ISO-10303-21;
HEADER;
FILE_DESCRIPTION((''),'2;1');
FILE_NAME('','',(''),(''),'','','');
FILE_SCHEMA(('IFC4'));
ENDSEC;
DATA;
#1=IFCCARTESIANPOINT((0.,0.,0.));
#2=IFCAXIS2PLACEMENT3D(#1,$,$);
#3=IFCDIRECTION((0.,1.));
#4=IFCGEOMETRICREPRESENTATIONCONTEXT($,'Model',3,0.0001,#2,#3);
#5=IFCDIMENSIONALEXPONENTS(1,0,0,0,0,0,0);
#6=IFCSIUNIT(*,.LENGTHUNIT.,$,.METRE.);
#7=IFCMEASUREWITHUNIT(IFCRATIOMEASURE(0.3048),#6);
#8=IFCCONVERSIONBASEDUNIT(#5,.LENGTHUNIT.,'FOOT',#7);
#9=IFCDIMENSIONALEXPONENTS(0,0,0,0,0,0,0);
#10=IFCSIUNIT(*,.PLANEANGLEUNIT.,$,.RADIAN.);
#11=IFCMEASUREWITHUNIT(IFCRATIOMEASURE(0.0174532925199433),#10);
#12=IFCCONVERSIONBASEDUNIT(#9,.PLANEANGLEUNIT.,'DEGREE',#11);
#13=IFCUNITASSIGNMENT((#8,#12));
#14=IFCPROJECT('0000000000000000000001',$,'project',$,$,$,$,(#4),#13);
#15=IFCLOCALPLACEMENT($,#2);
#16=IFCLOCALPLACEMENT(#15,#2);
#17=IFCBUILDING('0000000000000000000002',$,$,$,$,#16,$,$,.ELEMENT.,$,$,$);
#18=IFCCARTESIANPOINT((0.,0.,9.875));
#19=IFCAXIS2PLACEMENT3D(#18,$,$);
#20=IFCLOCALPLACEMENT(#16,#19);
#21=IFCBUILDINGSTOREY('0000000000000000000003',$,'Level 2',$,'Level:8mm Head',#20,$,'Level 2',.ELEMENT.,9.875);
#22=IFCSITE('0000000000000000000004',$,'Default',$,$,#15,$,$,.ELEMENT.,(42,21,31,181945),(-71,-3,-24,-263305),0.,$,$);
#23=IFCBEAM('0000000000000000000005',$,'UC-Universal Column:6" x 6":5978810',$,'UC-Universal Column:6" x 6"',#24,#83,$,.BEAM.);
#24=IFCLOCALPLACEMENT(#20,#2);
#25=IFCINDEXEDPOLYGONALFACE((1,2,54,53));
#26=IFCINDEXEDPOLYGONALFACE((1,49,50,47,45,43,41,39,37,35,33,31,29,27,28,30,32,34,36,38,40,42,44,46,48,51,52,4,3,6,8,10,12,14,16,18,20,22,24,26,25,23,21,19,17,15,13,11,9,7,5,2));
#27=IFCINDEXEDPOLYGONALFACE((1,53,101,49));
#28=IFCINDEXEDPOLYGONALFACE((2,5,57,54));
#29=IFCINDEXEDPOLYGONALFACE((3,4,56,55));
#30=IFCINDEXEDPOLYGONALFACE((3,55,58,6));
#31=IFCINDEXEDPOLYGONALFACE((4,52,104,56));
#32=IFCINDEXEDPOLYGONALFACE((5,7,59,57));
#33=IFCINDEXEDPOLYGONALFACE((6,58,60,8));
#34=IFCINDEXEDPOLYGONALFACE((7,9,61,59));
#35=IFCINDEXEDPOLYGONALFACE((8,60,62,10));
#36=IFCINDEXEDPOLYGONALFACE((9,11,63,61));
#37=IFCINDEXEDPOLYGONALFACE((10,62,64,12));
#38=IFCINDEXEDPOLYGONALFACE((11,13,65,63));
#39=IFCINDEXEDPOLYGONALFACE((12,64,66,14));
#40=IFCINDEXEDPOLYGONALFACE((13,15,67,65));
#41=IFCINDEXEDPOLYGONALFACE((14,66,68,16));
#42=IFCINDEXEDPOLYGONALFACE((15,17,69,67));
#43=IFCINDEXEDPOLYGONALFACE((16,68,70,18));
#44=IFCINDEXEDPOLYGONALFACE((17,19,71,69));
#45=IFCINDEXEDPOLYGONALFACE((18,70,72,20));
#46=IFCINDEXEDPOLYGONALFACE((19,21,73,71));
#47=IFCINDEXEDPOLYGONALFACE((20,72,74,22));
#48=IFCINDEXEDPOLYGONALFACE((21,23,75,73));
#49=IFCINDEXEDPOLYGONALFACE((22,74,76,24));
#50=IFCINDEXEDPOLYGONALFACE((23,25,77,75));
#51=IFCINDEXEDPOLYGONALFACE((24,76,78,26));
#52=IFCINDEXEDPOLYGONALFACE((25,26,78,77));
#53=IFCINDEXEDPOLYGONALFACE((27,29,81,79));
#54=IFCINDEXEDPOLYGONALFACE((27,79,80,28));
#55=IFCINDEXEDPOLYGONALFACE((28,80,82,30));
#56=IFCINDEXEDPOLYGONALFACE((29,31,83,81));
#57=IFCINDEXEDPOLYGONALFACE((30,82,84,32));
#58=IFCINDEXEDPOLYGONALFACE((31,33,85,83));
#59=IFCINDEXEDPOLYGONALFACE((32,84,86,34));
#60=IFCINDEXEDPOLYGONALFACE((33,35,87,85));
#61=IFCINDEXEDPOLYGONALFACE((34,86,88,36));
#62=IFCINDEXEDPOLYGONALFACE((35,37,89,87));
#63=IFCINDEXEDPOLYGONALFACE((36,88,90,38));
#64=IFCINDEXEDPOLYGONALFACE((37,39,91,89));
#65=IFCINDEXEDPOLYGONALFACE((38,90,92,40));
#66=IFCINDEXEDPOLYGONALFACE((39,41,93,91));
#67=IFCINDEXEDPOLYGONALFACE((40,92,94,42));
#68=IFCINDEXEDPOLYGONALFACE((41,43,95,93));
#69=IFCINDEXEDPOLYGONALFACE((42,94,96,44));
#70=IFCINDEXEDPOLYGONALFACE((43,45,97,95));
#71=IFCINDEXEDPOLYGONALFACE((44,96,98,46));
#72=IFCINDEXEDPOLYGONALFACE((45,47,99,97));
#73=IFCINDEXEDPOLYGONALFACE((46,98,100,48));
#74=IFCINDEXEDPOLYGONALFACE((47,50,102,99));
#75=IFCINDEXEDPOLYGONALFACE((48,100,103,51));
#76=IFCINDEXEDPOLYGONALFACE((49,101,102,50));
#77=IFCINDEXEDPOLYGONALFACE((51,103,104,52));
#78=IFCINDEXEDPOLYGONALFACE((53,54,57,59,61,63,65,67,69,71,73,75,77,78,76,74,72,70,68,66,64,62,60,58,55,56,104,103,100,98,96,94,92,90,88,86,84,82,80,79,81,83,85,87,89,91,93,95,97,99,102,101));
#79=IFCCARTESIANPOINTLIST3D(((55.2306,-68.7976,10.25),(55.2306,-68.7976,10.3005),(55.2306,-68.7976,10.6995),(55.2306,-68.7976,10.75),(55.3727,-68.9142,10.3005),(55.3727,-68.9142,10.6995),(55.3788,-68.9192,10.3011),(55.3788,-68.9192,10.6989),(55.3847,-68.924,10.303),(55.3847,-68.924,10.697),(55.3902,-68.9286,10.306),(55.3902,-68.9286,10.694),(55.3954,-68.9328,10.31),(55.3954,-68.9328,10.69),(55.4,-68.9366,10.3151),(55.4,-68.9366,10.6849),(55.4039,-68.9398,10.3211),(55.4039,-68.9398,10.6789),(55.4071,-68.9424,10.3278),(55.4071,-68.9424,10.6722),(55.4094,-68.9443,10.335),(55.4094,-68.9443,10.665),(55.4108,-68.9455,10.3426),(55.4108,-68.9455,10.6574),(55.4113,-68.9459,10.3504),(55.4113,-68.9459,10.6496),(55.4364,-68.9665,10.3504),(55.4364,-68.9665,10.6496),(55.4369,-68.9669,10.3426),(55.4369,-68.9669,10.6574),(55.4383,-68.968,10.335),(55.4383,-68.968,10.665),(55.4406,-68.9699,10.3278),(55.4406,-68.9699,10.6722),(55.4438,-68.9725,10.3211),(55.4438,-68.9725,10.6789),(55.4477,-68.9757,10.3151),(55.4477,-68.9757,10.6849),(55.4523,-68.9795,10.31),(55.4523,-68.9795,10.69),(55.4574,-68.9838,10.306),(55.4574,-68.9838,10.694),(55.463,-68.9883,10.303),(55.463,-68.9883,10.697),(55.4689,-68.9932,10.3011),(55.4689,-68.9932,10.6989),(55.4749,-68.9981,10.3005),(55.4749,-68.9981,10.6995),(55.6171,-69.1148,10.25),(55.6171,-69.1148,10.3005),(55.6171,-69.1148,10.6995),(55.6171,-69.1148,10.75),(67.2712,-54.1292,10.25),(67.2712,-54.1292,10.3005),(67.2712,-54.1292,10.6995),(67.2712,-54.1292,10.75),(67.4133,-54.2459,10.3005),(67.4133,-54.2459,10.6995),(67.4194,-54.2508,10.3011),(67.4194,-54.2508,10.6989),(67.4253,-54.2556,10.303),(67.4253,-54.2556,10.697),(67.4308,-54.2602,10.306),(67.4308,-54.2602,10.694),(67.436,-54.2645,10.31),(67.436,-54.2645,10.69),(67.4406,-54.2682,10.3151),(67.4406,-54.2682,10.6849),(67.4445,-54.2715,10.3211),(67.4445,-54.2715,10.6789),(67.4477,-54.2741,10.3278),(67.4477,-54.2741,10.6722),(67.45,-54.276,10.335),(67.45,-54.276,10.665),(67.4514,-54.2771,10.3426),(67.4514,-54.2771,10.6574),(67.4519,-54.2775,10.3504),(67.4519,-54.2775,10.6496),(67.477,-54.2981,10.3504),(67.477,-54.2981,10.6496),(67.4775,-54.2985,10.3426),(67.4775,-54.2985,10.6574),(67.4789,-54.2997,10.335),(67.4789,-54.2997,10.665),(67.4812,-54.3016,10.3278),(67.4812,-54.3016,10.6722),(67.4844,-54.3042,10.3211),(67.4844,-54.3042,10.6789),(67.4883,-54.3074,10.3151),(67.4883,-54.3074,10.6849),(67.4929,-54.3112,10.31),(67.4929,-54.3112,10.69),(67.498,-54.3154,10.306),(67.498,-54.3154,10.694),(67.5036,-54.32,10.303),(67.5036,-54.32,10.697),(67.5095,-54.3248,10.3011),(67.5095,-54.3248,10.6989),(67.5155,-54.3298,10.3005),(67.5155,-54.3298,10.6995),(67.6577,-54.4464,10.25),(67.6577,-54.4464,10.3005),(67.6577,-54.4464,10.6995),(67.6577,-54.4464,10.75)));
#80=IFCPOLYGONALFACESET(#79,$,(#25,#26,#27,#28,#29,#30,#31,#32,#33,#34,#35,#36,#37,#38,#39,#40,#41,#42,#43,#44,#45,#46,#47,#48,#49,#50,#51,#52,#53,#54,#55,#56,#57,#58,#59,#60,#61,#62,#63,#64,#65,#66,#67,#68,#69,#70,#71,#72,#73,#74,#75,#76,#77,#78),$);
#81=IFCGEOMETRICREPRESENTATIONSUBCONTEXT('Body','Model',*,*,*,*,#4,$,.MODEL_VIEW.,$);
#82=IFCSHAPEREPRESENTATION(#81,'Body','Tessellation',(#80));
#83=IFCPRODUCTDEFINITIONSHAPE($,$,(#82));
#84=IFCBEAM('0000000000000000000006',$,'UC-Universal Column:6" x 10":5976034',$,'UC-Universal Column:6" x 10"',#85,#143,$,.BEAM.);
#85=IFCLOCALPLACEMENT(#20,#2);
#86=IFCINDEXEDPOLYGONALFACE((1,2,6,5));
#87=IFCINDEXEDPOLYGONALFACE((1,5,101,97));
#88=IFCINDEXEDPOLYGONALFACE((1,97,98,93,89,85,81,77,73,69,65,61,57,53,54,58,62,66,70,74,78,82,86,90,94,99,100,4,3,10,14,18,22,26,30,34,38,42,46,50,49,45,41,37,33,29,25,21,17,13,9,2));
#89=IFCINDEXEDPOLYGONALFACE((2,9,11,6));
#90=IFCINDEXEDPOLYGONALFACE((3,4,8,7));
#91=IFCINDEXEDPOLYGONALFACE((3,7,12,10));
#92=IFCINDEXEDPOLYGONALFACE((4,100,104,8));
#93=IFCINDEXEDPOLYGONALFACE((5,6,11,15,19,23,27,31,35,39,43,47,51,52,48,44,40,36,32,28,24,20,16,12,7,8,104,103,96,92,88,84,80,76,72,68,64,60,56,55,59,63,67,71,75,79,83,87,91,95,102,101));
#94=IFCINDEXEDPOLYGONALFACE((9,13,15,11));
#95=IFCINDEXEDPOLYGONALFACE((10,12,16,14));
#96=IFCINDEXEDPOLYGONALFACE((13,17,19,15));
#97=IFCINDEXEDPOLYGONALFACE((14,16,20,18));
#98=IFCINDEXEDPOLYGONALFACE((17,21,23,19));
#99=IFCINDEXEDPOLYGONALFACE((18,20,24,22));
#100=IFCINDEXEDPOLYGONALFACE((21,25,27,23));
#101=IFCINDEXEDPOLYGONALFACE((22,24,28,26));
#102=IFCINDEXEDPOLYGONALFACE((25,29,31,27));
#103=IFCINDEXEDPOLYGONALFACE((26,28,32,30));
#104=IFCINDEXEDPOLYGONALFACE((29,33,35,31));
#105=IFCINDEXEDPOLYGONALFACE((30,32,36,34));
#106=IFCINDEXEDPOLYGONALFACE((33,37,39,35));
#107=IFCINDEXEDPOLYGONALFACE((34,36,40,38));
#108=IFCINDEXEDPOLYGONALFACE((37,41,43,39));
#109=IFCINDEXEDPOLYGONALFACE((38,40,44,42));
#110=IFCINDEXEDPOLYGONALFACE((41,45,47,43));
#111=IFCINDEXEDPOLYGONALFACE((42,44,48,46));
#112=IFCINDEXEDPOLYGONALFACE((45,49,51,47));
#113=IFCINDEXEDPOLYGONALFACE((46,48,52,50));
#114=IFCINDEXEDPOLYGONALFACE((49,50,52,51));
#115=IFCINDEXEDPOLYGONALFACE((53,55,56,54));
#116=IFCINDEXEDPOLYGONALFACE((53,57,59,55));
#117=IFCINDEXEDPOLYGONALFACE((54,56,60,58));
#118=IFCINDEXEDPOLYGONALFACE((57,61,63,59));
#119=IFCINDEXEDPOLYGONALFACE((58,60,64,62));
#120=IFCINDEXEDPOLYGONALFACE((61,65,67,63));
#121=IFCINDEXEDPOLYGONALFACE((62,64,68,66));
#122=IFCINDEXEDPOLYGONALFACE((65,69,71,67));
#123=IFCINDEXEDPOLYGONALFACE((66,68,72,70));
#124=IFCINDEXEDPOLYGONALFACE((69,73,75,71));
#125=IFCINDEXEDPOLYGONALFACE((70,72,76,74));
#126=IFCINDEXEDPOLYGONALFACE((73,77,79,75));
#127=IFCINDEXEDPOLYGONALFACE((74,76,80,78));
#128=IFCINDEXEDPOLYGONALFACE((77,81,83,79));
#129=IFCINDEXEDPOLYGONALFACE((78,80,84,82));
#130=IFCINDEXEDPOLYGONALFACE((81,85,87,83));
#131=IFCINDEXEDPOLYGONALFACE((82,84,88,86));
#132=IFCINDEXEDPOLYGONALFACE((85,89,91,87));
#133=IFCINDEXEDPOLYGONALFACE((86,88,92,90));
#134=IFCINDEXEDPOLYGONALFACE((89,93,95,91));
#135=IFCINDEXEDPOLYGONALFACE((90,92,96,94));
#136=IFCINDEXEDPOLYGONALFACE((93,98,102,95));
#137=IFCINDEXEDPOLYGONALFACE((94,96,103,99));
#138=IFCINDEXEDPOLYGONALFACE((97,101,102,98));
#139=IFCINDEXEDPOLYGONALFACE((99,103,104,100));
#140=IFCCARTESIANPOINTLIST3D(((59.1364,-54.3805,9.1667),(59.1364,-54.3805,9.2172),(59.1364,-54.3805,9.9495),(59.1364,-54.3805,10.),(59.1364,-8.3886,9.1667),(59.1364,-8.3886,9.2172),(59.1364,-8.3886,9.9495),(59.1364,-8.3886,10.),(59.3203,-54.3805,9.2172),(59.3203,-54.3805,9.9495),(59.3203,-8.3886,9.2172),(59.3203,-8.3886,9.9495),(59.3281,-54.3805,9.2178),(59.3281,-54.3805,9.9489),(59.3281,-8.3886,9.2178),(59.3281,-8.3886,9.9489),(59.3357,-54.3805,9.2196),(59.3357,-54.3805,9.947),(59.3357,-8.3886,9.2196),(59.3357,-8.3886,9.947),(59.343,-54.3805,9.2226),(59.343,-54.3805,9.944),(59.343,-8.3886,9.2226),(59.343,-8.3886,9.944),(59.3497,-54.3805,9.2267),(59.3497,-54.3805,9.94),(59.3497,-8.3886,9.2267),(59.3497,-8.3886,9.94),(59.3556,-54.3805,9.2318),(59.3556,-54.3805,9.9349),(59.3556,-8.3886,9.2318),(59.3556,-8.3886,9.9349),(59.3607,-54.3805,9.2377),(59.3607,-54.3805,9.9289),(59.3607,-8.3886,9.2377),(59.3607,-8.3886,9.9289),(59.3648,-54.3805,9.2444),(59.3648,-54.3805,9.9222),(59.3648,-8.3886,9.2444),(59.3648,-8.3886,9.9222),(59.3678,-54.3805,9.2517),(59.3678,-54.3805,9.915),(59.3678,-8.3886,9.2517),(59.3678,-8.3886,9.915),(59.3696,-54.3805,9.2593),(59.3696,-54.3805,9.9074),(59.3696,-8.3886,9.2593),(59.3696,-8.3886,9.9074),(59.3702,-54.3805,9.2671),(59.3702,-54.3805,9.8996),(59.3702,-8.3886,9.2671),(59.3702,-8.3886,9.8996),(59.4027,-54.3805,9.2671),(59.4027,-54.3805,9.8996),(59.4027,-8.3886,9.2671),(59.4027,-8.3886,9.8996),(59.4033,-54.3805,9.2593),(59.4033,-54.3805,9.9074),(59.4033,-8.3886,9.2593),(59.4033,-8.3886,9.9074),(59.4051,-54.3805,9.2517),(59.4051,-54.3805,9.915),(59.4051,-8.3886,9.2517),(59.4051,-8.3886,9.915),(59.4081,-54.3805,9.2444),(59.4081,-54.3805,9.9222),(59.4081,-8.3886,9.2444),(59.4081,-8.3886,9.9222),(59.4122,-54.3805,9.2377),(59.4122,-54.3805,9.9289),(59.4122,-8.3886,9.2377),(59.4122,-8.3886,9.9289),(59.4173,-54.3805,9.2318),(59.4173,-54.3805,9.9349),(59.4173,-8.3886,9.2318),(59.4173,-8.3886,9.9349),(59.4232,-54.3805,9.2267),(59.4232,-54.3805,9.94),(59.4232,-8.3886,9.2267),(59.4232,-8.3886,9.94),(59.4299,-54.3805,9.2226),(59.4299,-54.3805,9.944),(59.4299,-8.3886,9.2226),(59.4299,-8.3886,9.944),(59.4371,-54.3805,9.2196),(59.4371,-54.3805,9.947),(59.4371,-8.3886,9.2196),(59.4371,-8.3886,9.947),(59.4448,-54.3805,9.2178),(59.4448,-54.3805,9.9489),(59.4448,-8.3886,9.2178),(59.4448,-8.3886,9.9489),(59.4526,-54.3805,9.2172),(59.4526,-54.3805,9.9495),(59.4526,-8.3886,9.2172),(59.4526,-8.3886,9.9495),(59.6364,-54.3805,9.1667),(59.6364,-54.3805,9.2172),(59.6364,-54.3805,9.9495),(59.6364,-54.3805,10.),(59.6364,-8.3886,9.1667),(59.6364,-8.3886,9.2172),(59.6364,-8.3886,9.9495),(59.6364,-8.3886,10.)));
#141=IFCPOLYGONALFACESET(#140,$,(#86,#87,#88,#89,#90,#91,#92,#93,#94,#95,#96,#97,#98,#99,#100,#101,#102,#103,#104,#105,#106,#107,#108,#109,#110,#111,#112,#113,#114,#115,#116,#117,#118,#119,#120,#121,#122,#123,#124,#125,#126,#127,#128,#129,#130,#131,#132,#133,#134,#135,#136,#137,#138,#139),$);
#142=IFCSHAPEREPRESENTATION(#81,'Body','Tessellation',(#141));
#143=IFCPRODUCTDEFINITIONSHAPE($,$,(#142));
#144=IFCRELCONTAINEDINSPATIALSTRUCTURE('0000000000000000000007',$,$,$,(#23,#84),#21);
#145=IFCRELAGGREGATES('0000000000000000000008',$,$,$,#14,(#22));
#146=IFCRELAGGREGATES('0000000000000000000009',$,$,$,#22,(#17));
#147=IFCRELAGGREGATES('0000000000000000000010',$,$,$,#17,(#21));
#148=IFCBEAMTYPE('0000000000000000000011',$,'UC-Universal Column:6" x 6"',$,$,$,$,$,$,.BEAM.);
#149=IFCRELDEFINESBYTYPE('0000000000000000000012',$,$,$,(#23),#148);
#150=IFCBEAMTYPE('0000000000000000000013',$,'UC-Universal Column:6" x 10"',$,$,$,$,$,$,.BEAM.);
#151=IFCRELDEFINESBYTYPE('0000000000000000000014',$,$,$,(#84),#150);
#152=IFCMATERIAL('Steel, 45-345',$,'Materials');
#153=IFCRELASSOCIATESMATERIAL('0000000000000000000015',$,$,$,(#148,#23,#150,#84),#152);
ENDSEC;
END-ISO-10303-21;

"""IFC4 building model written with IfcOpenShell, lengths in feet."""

from ifc_helpers import new_model, entity, si_unit, converted_unit, direction, frame, origin, place, context, subcontext, project, spatial, indexed_curve, outline, extrude, source, transform, mapped, material, type_object, type_shapes, element, save


model = new_model("IFC4")

# Units and contexts
model_context = context("Model", 3, precision=0.0001, world=origin(), true_north=direction((0.0, 1.0)))
body_context = subcontext(model_context, "Body", "Model", "MODEL_VIEW")
ifc_project = project(units=[converted_unit("LENGTHUNIT", "FOOT", entity("IfcRatioMeasure", 0.3048), si_unit("LENGTHUNIT", "METRE"), dimensions=[1, 0, 0, 0, 0, 0, 0]), converted_unit("PLANEANGLEUNIT", "DEGREE", entity("IfcRatioMeasure", 0.0174532925199433), si_unit("PLANEANGLEUNIT", "RADIAN"), dimensions=[0, 0, 0, 0, 0, 0, 0])], contexts=[model_context])

# Site, building, storey
site_placement = place(None, origin())
site = spatial("IfcSite", under=ifc_project, at=site_placement, Name="Default", CompositionType="ELEMENT", RefLatitude=(42, 21, 31, 181945), RefLongitude=(-71, -3, -24, -263305), RefElevation=0.0)
building_placement = place(site_placement, origin())
building = spatial("IfcBuilding", under=site, at=building_placement, CompositionType="ELEMENT")
storey_placement = place(building_placement, frame((0.0, 0.0, 9.875)))
storey = spatial("IfcBuildingStorey", under=building, at=storey_placement, Name="Level 2", ObjectType="Level:8mm Head", LongName="Level 2", CompositionType="ELEMENT", Elevation=9.875)

# Beams
ifc_material_1 = material(Name="Steel, 45-345", Category="Materials")
beam_type_1 = type_object("IfcBeamType", Name="UC-Universal Column:6\" x 6\"", PredefinedType="BEAM", material=ifc_material_1)
shared_shape_1 = source(origin(), body_context, "Body", "SweptSolid", [
    extrude(outline(indexed_curve([(-0.25, -0.25), (-0.1995, -0.25), (-0.1995, -0.0661), (-0.1989, -0.0583), (-0.197, -0.0507), (-0.194, -0.0435), (-0.19, -0.0368), (-0.1849, -0.0308), (-0.1789, -0.0258), (-0.1722, -0.0217), (-0.165, -0.0187), (-0.1574, -0.0169), (-0.1496, -0.0162), (0.1496, -0.0162), (0.1574, -0.0169), (0.165, -0.0187), (0.1722, -0.0217), (0.1789, -0.0258), (0.1849, -0.0308), (0.19, -0.0368), (0.194, -0.0435), (0.197, -0.0507), (0.1989, -0.0583), (0.1995, -0.0661), (0.1995, -0.25), (0.25, -0.25), (0.25, 0.25), (0.1995, 0.25), (0.1995, 0.0661), (0.1989, 0.0583), (0.197, 0.0507), (0.194, 0.0435), (0.19, 0.0368), (0.1849, 0.0308), (0.1789, 0.0258), (0.1722, 0.0217), (0.165, 0.0187), (0.1574, 0.0169), (0.1496, 0.0162), (-0.1496, 0.0162), (-0.1574, 0.0169), (-0.165, 0.0187), (-0.1722, 0.0217), (-0.1789, 0.0258), (-0.1849, 0.0308), (-0.19, 0.0368), (-0.194, 0.0435), (-0.197, 0.0507), (-0.1989, 0.0583), (-0.1995, 0.0661), (-0.1995, 0.25), (-0.25, 0.25), (-0.25, -0.25)], self_intersect=False)), frame((-9.2456, 0.0, 0.0), z_axis=(1.0, 0.0, 0.0), x_axis=(0.0, 0.0, -1.0)), (0.0, 0.0, 1.0), 18.9773),
])
type_shapes(beam_type_1, [shared_shape_1])
beam_1_placement = place(storey_placement, frame((61.5984, -61.4341, 10.5), z_axis=(0.0, 0.0, 1.0), x_axis=(-0.634475, -0.772943, 0.0)))
element("IfcBeam", 1, at=beam_1_placement, inside=storey, type_object=beam_type_1, material=ifc_material_1, Name="UC-Universal Column:6\" x 6\":5978810", ObjectType="UC-Universal Column:6\" x 6\"", PredefinedType="BEAM", context=body_context, shape_type="MappedRepresentation", body=[
    mapped(shared_shape_1, transform((0.0, 0.0, 0.0), scale=1.0)),
])
beam_type_2 = type_object("IfcBeamType", Name="UC-Universal Column:6\" x 10\"", PredefinedType="BEAM", material=ifc_material_1)
shared_shape_2 = source(origin(), body_context, "Body", "SweptSolid", [
    extrude(outline(indexed_curve([(-0.4167, -0.25), (-0.3661, -0.25), (-0.3661, -0.0661), (-0.3655, -0.0583), (-0.3637, -0.0507), (-0.3607, -0.0435), (-0.3566, -0.0368), (-0.3515, -0.0308), (-0.3456, -0.0258), (-0.3389, -0.0217), (-0.3317, -0.0187), (-0.3241, -0.0169), (-0.3163, -0.0162), (0.3163, -0.0162), (0.3241, -0.0169), (0.3317, -0.0187), (0.3389, -0.0217), (0.3456, -0.0258), (0.3515, -0.0308), (0.3566, -0.0368), (0.3607, -0.0435), (0.3637, -0.0507), (0.3655, -0.0583), (0.3661, -0.0661), (0.3661, -0.25), (0.4167, -0.25), (0.4167, 0.25), (0.3661, 0.25), (0.3661, 0.0661), (0.3655, 0.0583), (0.3637, 0.0507), (0.3607, 0.0435), (0.3566, 0.0368), (0.3515, 0.0308), (0.3456, 0.0258), (0.3389, 0.0217), (0.3317, 0.0187), (0.3241, 0.0169), (0.3163, 0.0162), (-0.3163, 0.0162), (-0.3241, 0.0169), (-0.3317, 0.0187), (-0.3389, 0.0217), (-0.3456, 0.0258), (-0.3515, 0.0308), (-0.3566, 0.0368), (-0.3607, 0.0435), (-0.3637, 0.0507), (-0.3655, 0.0583), (-0.3661, 0.0661), (-0.3661, 0.25), (-0.4167, 0.25), (-0.4167, -0.25)], self_intersect=False)), frame((6.6969, 0.0, 0.0), z_axis=(1.0, 0.0, 0.0), x_axis=(0.0, 0.0, -1.0)), (0.0, 0.0, 1.0), 45.9919),
])
type_shapes(beam_type_2, [shared_shape_2])
beam_2_placement = place(storey_placement, frame((59.3864, -61.0774, 9.5833), z_axis=(0.0, 0.0, 1.0), x_axis=(0.0, 1.0, 0.0)))
element("IfcBeam", 2, at=beam_2_placement, inside=storey, type_object=beam_type_2, material=ifc_material_1, Name="UC-Universal Column:6\" x 10\":5976034", ObjectType="UC-Universal Column:6\" x 10\"", PredefinedType="BEAM", context=body_context, shape_type="MappedRepresentation", body=[
    mapped(shared_shape_2, transform((0.0, 0.0, 0.0), scale=1.0)),
])

save(model, "model.ifc")
